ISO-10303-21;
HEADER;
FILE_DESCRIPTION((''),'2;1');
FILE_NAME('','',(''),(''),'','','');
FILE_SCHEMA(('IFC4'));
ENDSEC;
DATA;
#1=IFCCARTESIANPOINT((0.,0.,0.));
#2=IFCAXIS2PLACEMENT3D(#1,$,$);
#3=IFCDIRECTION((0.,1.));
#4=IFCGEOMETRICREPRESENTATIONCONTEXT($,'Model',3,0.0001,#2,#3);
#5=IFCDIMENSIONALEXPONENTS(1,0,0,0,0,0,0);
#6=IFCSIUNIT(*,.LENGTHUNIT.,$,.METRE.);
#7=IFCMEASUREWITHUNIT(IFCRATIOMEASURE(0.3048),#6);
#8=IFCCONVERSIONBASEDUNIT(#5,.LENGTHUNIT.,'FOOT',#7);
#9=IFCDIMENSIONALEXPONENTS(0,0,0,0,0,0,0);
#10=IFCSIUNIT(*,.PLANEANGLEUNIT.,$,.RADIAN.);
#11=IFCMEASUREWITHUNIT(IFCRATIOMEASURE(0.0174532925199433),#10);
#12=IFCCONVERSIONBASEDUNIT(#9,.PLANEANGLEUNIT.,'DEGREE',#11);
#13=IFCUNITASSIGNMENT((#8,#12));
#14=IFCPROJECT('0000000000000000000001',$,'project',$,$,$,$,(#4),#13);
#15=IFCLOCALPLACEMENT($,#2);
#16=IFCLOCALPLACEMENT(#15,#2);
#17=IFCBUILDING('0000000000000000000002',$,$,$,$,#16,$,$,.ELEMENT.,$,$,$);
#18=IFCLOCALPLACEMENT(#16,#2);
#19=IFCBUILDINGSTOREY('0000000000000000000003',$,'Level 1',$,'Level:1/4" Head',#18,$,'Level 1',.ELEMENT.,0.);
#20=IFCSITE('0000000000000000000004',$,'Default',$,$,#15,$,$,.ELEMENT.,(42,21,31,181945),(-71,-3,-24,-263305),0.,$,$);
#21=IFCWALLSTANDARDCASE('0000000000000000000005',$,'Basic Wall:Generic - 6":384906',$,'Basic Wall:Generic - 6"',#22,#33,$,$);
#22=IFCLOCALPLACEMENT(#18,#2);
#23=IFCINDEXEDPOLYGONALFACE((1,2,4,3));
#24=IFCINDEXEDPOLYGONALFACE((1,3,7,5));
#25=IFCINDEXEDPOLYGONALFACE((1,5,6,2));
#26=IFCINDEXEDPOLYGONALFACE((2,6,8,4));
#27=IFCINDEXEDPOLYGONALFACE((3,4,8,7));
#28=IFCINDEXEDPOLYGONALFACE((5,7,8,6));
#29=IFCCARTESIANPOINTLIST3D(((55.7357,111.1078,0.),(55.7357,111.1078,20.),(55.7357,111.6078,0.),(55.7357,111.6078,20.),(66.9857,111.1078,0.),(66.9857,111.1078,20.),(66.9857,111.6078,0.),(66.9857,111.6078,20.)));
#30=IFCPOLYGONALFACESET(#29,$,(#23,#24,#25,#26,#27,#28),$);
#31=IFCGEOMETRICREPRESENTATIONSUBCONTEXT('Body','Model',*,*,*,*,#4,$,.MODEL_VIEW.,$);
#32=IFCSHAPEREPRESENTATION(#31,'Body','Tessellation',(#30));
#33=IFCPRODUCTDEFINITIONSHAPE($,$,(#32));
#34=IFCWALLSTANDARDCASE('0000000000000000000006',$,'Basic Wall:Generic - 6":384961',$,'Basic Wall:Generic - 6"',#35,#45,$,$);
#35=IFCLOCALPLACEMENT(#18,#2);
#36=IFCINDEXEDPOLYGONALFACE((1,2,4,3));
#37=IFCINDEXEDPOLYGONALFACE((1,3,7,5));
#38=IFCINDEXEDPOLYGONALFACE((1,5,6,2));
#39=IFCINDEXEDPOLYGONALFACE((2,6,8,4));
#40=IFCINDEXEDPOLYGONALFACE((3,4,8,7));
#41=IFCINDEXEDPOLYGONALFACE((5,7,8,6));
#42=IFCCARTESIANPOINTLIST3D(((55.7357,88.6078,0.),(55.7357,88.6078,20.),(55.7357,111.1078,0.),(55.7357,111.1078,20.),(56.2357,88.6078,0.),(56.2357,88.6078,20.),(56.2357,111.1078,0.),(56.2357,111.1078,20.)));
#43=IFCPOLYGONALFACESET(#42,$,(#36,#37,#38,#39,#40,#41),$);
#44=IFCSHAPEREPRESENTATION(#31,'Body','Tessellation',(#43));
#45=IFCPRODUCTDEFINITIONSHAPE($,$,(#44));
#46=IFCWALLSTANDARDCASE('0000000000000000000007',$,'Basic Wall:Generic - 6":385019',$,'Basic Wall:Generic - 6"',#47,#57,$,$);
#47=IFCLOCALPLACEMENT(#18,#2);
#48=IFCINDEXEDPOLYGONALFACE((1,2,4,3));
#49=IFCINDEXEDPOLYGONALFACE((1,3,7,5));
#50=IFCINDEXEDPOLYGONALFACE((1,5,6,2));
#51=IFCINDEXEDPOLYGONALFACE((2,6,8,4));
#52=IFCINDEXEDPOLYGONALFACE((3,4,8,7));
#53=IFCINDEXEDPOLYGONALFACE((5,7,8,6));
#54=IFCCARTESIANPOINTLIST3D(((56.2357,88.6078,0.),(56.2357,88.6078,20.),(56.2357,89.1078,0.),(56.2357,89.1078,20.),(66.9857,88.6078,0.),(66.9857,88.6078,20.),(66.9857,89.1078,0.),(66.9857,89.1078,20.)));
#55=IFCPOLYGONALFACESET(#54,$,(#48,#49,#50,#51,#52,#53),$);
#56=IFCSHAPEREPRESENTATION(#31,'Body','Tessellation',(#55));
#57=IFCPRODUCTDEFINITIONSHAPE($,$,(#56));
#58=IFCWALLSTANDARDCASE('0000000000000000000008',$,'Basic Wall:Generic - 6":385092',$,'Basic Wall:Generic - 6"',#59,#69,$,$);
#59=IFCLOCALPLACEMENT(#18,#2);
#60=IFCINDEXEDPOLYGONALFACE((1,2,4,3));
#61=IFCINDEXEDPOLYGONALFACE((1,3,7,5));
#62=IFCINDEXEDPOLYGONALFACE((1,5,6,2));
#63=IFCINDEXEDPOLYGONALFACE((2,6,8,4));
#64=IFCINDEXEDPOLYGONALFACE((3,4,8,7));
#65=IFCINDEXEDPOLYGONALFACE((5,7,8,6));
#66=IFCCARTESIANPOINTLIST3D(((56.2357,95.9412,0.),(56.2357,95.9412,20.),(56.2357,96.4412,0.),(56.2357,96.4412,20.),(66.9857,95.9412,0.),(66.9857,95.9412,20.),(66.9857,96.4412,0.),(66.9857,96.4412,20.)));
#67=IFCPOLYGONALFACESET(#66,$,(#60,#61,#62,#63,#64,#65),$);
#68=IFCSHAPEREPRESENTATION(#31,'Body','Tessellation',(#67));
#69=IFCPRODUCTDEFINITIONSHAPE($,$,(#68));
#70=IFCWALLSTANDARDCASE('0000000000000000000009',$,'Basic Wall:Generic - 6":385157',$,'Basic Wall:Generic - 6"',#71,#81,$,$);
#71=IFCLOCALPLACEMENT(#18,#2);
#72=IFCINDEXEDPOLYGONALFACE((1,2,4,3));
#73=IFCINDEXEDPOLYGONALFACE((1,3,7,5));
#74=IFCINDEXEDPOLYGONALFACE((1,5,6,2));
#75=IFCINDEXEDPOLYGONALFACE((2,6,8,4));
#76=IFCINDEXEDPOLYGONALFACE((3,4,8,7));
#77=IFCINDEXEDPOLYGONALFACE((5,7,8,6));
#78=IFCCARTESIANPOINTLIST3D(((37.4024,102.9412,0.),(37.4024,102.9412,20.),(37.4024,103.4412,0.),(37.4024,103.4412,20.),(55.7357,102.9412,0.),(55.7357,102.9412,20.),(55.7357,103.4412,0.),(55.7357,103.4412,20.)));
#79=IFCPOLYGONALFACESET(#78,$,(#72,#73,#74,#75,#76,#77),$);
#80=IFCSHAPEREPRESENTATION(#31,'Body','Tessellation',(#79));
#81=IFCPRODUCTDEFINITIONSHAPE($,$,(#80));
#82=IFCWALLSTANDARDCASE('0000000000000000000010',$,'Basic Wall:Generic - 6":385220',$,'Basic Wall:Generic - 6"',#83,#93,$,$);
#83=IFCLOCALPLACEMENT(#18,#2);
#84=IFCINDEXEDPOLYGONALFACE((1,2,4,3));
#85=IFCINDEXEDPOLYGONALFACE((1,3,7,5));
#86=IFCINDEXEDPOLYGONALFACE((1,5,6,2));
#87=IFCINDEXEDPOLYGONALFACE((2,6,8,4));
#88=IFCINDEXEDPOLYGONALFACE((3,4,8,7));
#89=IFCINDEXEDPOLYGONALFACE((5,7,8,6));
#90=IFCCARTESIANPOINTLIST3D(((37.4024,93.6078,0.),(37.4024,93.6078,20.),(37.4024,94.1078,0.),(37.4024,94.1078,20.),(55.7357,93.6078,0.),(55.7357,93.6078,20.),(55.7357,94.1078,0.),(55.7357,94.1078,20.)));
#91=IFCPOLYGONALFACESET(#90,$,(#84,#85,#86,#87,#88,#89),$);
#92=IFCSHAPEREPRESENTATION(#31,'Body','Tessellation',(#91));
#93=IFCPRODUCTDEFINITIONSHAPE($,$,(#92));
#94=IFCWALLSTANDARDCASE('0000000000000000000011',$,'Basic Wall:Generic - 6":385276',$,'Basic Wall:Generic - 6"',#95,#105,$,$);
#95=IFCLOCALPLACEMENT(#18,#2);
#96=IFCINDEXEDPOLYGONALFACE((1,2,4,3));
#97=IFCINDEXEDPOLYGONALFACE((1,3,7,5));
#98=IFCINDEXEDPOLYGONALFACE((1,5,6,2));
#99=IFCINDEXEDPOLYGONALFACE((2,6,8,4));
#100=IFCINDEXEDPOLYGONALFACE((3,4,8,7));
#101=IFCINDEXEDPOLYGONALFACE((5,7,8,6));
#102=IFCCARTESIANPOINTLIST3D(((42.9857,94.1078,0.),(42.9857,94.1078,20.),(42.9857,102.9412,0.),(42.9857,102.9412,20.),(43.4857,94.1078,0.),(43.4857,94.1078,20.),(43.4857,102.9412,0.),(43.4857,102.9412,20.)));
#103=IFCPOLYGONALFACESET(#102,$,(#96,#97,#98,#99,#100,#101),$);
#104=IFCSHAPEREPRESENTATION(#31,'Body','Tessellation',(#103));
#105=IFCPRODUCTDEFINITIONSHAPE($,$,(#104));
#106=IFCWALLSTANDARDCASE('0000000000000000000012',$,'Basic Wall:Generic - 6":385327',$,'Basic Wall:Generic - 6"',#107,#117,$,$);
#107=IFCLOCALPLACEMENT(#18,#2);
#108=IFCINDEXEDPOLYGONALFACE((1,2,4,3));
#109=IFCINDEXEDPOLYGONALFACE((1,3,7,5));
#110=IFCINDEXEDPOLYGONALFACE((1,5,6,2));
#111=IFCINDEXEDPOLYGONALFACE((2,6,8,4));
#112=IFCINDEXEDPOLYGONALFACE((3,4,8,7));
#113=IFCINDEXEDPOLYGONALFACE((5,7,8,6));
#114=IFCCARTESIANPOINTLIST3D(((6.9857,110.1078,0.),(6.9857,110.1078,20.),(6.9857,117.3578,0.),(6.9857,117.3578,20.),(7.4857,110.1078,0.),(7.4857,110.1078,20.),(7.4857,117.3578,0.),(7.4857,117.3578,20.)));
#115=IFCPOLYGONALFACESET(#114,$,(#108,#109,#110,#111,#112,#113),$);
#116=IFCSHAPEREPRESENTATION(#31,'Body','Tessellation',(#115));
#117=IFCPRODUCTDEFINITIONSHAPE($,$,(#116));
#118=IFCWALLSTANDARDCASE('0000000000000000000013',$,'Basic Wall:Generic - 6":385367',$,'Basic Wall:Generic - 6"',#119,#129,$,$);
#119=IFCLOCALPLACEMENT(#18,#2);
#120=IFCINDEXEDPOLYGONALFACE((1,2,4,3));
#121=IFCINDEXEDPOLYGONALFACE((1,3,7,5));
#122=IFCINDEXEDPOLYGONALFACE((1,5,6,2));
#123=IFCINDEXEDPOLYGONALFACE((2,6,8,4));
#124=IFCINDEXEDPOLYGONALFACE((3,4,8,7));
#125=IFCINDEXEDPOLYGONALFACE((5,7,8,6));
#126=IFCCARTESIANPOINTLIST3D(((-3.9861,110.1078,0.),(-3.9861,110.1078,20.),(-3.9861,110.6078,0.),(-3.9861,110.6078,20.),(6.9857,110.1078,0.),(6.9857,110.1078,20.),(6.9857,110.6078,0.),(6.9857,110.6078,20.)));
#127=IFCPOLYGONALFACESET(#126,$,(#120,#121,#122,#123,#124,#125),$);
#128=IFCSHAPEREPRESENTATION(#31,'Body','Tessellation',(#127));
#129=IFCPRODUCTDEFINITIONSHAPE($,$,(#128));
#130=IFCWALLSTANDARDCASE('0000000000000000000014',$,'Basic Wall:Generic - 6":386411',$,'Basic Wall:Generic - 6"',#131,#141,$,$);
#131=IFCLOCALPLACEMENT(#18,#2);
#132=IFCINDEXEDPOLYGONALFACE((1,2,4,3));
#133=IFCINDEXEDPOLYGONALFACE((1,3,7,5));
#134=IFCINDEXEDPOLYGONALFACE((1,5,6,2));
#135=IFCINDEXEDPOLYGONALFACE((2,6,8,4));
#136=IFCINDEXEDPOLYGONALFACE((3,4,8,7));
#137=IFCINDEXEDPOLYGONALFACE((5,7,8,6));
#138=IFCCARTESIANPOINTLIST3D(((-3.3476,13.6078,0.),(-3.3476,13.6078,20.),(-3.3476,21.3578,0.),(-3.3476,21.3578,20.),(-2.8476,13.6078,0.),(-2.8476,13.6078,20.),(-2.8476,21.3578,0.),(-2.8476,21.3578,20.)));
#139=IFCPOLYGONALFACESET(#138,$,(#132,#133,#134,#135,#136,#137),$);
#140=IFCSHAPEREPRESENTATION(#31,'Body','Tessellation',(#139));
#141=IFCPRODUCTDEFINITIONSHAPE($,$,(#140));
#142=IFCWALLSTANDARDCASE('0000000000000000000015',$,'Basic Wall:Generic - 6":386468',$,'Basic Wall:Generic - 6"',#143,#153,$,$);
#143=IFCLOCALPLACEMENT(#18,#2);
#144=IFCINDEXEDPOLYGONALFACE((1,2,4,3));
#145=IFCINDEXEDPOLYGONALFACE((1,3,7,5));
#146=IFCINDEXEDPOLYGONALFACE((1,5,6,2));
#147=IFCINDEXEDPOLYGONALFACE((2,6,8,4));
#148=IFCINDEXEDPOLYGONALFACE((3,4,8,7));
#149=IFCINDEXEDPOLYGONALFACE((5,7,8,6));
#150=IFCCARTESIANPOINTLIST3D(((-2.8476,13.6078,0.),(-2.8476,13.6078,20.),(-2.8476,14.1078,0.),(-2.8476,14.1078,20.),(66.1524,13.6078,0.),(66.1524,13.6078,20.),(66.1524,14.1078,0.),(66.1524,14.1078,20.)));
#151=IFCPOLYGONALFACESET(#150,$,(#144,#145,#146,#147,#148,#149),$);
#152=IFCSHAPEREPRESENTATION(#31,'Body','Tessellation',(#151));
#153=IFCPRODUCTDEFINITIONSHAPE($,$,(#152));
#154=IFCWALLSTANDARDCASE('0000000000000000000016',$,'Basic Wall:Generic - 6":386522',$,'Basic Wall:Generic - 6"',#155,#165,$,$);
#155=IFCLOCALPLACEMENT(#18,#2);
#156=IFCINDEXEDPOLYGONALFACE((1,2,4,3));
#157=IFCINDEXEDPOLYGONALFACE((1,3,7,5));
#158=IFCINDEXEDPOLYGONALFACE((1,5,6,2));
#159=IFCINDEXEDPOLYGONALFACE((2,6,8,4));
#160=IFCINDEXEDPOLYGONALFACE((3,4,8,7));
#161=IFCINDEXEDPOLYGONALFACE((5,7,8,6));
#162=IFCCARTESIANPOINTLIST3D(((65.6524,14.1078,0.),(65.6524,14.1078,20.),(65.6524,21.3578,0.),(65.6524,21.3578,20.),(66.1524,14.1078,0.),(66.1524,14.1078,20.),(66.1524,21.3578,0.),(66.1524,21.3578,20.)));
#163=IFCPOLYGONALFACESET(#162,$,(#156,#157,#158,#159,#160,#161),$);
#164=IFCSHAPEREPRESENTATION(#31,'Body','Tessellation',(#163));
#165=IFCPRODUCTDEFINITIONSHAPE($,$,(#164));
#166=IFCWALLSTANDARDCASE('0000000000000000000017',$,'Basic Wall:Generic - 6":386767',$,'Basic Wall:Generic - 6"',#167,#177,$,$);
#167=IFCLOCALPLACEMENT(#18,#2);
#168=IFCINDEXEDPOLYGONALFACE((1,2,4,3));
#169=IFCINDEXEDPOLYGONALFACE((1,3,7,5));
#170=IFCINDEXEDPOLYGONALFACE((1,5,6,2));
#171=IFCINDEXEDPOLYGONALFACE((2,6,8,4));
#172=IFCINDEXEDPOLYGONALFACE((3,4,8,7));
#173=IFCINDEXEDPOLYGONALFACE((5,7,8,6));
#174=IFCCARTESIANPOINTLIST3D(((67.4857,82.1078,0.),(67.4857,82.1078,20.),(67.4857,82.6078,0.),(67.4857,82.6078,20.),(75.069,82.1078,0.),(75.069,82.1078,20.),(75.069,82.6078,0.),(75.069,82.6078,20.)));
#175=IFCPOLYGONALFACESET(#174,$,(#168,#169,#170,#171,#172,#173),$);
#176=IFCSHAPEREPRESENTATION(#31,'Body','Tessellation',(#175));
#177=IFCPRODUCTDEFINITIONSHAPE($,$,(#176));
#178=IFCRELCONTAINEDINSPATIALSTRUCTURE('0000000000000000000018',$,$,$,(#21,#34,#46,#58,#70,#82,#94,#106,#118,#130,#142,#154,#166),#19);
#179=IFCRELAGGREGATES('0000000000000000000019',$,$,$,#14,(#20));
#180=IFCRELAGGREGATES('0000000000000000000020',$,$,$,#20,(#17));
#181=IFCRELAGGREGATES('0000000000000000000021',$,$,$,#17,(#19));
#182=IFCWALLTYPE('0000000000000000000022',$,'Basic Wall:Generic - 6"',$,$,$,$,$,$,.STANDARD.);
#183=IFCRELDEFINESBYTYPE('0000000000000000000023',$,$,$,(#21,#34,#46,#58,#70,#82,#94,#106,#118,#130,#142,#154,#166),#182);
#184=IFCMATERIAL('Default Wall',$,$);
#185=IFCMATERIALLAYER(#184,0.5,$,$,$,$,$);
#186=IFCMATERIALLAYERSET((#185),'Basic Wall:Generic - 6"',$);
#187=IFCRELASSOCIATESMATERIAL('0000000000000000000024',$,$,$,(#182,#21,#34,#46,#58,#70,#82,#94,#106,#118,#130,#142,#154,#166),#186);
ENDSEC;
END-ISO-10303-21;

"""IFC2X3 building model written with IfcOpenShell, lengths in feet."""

from ifc_helpers import new_model, entity, si_unit, converted_unit, direction, frame, frame_2d, origin, place, context, subcontext, project, spatial, rectangle, extrude, material, layer, layer_set, layer_usage, type_object, element, save


model = new_model("IFC2X3")

# Units and contexts
model_context = context("Model", 3, precision=0.0001, world=origin(), true_north=direction((0.0, 1.0)))
body_context = subcontext(model_context, "Body", "Model", "MODEL_VIEW")
ifc_project = project(units=[converted_unit("LENGTHUNIT", "FOOT", entity("IfcRatioMeasure", 0.3048), si_unit("LENGTHUNIT", "METRE"), dimensions=[1, 0, 0, 0, 0, 0, 0]), converted_unit("PLANEANGLEUNIT", "DEGREE", entity("IfcRatioMeasure", 0.0174532925199433), si_unit("PLANEANGLEUNIT", "RADIAN"), dimensions=[0, 0, 0, 0, 0, 0, 0])], contexts=[model_context])

# Site, building, storey
site_placement = place(None, origin())
site = spatial("IfcSite", under=ifc_project, at=site_placement, Name="Default", CompositionType="ELEMENT", RefLatitude=(42, 21, 31, 181945), RefLongitude=(-71, -3, -24, -263305), RefElevation=0.0)
building_placement = place(site_placement, origin())
building = spatial("IfcBuilding", under=site, at=building_placement, CompositionType="ELEMENT")
storey_placement = place(building_placement, origin())
storey = spatial("IfcBuildingStorey", under=building, at=storey_placement, Name="Level 1", ObjectType="Level:1/4\" Head", LongName="Level 1", CompositionType="ELEMENT", Elevation=0.0)

# Shared definitions
ifc_material = material(Name="Default Wall")
ifc_layer_1 = layer(ifc_material, 0.5)
ifc_layer_set_1 = layer_set([ifc_layer_1], Name="Basic Wall:Generic - 6\"")
wall_type_1 = type_object("IfcWallType", Name="Basic Wall:Generic - 6\"", PredefinedType="STANDARD", material=ifc_layer_set_1)

# Walls
ifc_layer_usage_1 = layer_usage(ifc_layer_set_1, "AXIS2", "NEGATIVE", 0.25)
wall_1_placement = place(storey_placement, frame((66.9857, 111.3578, 0.0), z_axis=(0.0, 0.0, 1.0), x_axis=(-1.0, 0.0, 0.0)))
element("IfcWallStandardCase", 1, at=wall_1_placement, inside=storey, type_object=wall_type_1, material=ifc_layer_usage_1, Name="Basic Wall:Generic - 6\":384906", ObjectType="Basic Wall:Generic - 6\"", context=body_context, shape_type="SweptSolid", body=[
    extrude(rectangle(XDim=11.25, YDim=0.5, at=frame_2d((5.625, 0.0), x_axis=(-1.0, 0.0))), origin(), (0.0, 0.0, 1.0), 20.0),
])
ifc_layer_usage_2 = layer_usage(ifc_layer_set_1, "AXIS2", "NEGATIVE", 0.25)
wall_2_placement = place(storey_placement, frame((55.9857, 111.1078, 0.0), z_axis=(0.0, 0.0, 1.0), x_axis=(0.0, -1.0, 0.0)))
element("IfcWallStandardCase", 2, at=wall_2_placement, inside=storey, type_object=wall_type_1, material=ifc_layer_usage_2, Name="Basic Wall:Generic - 6\":384961", ObjectType="Basic Wall:Generic - 6\"", context=body_context, shape_type="SweptSolid", body=[
    extrude(rectangle(XDim=22.5, YDim=0.5, at=frame_2d((11.25, 0.0), x_axis=(-1.0, 0.0))), origin(), (0.0, 0.0, 1.0), 20.0),
])
ifc_layer_usage_3 = layer_usage(ifc_layer_set_1, "AXIS2", "NEGATIVE", 0.25)
wall_3_placement = place(storey_placement, frame((56.2357, 88.8578, 0.0)))
element("IfcWallStandardCase", 3, at=wall_3_placement, inside=storey, type_object=wall_type_1, material=ifc_layer_usage_3, Name="Basic Wall:Generic - 6\":385019", ObjectType="Basic Wall:Generic - 6\"", context=body_context, shape_type="SweptSolid", body=[
    extrude(rectangle(XDim=10.75, YDim=0.5, at=frame_2d((5.375, 0.0), x_axis=(-1.0, 0.0))), origin(), (0.0, 0.0, 1.0), 20.0),
])
ifc_layer_usage_4 = layer_usage(ifc_layer_set_1, "AXIS2", "NEGATIVE", 0.25)
wall_4_placement = place(storey_placement, frame((66.9857, 96.1912, 0.0), z_axis=(0.0, 0.0, 1.0), x_axis=(-1.0, 0.0, 0.0)))
element("IfcWallStandardCase", 4, at=wall_4_placement, inside=storey, type_object=wall_type_1, material=ifc_layer_usage_4, Name="Basic Wall:Generic - 6\":385092", ObjectType="Basic Wall:Generic - 6\"", context=body_context, shape_type="SweptSolid", body=[
    extrude(rectangle(XDim=10.75, YDim=0.5, at=frame_2d((5.375, 0.0), x_axis=(-1.0, 0.0))), origin(), (0.0, 0.0, 1.0), 20.0),
])
ifc_layer_usage_5 = layer_usage(ifc_layer_set_1, "AXIS2", "NEGATIVE", 0.25)
wall_5_placement = place(storey_placement, frame((55.7357, 103.1912, 0.0), z_axis=(0.0, 0.0, 1.0), x_axis=(-1.0, 0.0, 0.0)))
element("IfcWallStandardCase", 5, at=wall_5_placement, inside=storey, type_object=wall_type_1, material=ifc_layer_usage_5, Name="Basic Wall:Generic - 6\":385157", ObjectType="Basic Wall:Generic - 6\"", context=body_context, shape_type="SweptSolid", body=[
    extrude(rectangle(XDim=18.3333, YDim=0.5, at=frame_2d((9.1667, 0.0), x_axis=(-1.0, 0.0))), origin(), (0.0, 0.0, 1.0), 20.0),
])
ifc_layer_usage_6 = layer_usage(ifc_layer_set_1, "AXIS2", "NEGATIVE", 0.25)
wall_6_placement = place(storey_placement, frame((37.4024, 93.8578, 0.0)))
element("IfcWallStandardCase", 6, at=wall_6_placement, inside=storey, type_object=wall_type_1, material=ifc_layer_usage_6, Name="Basic Wall:Generic - 6\":385220", ObjectType="Basic Wall:Generic - 6\"", context=body_context, shape_type="SweptSolid", body=[
    extrude(rectangle(XDim=18.3333, YDim=0.5, at=frame_2d((9.1667, 0.0), x_axis=(-1.0, 0.0))), origin(), (0.0, 0.0, 1.0), 20.0),
])
ifc_layer_usage_7 = layer_usage(ifc_layer_set_1, "AXIS2", "NEGATIVE", 0.25)
wall_7_placement = place(storey_placement, frame((43.2357, 94.1078, 0.0), z_axis=(0.0, 0.0, 1.0), x_axis=(0.0, 1.0, 0.0)))
element("IfcWallStandardCase", 7, at=wall_7_placement, inside=storey, type_object=wall_type_1, material=ifc_layer_usage_7, Name="Basic Wall:Generic - 6\":385276", ObjectType="Basic Wall:Generic - 6\"", context=body_context, shape_type="SweptSolid", body=[
    extrude(rectangle(XDim=8.8333, YDim=0.5, at=frame_2d((4.4167, 0.0), x_axis=(-1.0, 0.0))), origin(), (0.0, 0.0, 1.0), 20.0),
])
ifc_layer_usage_8 = layer_usage(ifc_layer_set_1, "AXIS2", "NEGATIVE", 0.25)
wall_8_placement = place(storey_placement, frame((7.2357, 117.3578, 0.0), z_axis=(0.0, 0.0, 1.0), x_axis=(0.0, -1.0, 0.0)))
element("IfcWallStandardCase", 8, at=wall_8_placement, inside=storey, type_object=wall_type_1, material=ifc_layer_usage_8, Name="Basic Wall:Generic - 6\":385327", ObjectType="Basic Wall:Generic - 6\"", context=body_context, shape_type="SweptSolid", body=[
    extrude(rectangle(XDim=7.25, YDim=0.5, at=frame_2d((3.625, 0.0), x_axis=(-1.0, 0.0))), origin(), (0.0, 0.0, 1.0), 20.0),
])
ifc_layer_usage_9 = layer_usage(ifc_layer_set_1, "AXIS2", "NEGATIVE", 0.25)
wall_9_placement = place(storey_placement, frame((6.9857, 110.3578, 0.0), z_axis=(0.0, 0.0, 1.0), x_axis=(-1.0, 0.0, 0.0)))
element("IfcWallStandardCase", 9, at=wall_9_placement, inside=storey, type_object=wall_type_1, material=ifc_layer_usage_9, Name="Basic Wall:Generic - 6\":385367", ObjectType="Basic Wall:Generic - 6\"", context=body_context, shape_type="SweptSolid", body=[
    extrude(rectangle(XDim=10.9718, YDim=0.5, at=frame_2d((5.4859, 0.0), x_axis=(-1.0, 0.0))), origin(), (0.0, 0.0, 1.0), 20.0),
])
ifc_layer_usage_10 = layer_usage(ifc_layer_set_1, "AXIS2", "NEGATIVE", 0.25)
wall_10_placement = place(storey_placement, frame((-3.0976, 21.3578, 0.0), z_axis=(0.0, 0.0, 1.0), x_axis=(0.0, -1.0, 0.0)))
element("IfcWallStandardCase", 10, at=wall_10_placement, inside=storey, type_object=wall_type_1, material=ifc_layer_usage_10, Name="Basic Wall:Generic - 6\":386411", ObjectType="Basic Wall:Generic - 6\"", context=body_context, shape_type="SweptSolid", body=[
    extrude(rectangle(XDim=7.75, YDim=0.5, at=frame_2d((3.875, 0.0), x_axis=(-1.0, 0.0))), origin(), (0.0, 0.0, 1.0), 20.0),
])
ifc_layer_usage_11 = layer_usage(ifc_layer_set_1, "AXIS2", "NEGATIVE", 0.25)
wall_11_placement = place(storey_placement, frame((-2.8476, 13.8578, 0.0)))
element("IfcWallStandardCase", 11, at=wall_11_placement, inside=storey, type_object=wall_type_1, material=ifc_layer_usage_11, Name="Basic Wall:Generic - 6\":386468", ObjectType="Basic Wall:Generic - 6\"", context=body_context, shape_type="SweptSolid", body=[
    extrude(rectangle(XDim=69.0, YDim=0.5, at=frame_2d((34.5, 0.0), x_axis=(-1.0, 0.0))), origin(), (0.0, 0.0, 1.0), 20.0),
])
ifc_layer_usage_12 = layer_usage(ifc_layer_set_1, "AXIS2", "NEGATIVE", 0.25)
wall_12_placement = place(storey_placement, frame((65.9024, 14.1078, 0.0), z_axis=(0.0, 0.0, 1.0), x_axis=(0.0, 1.0, 0.0)))
element("IfcWallStandardCase", 12, at=wall_12_placement, inside=storey, type_object=wall_type_1, material=ifc_layer_usage_12, Name="Basic Wall:Generic - 6\":386522", ObjectType="Basic Wall:Generic - 6\"", context=body_context, shape_type="SweptSolid", body=[
    extrude(rectangle(XDim=7.25, YDim=0.5, at=frame_2d((3.625, 0.0), x_axis=(-1.0, 0.0))), origin(), (0.0, 0.0, 1.0), 20.0),
])
ifc_layer_usage_13 = layer_usage(ifc_layer_set_1, "AXIS2", "NEGATIVE", 0.25)
wall_13_placement = place(storey_placement, frame((67.4857, 82.3578, 0.0)))
element("IfcWallStandardCase", 13, at=wall_13_placement, inside=storey, type_object=wall_type_1, material=ifc_layer_usage_13, Name="Basic Wall:Generic - 6\":386767", ObjectType="Basic Wall:Generic - 6\"", context=body_context, shape_type="SweptSolid", body=[
    extrude(rectangle(XDim=7.5833, YDim=0.5, at=frame_2d((3.7917, 0.0), x_axis=(-1.0, 0.0))), origin(), (0.0, 0.0, 1.0), 20.0),
])

save(model, "model.ifc")
